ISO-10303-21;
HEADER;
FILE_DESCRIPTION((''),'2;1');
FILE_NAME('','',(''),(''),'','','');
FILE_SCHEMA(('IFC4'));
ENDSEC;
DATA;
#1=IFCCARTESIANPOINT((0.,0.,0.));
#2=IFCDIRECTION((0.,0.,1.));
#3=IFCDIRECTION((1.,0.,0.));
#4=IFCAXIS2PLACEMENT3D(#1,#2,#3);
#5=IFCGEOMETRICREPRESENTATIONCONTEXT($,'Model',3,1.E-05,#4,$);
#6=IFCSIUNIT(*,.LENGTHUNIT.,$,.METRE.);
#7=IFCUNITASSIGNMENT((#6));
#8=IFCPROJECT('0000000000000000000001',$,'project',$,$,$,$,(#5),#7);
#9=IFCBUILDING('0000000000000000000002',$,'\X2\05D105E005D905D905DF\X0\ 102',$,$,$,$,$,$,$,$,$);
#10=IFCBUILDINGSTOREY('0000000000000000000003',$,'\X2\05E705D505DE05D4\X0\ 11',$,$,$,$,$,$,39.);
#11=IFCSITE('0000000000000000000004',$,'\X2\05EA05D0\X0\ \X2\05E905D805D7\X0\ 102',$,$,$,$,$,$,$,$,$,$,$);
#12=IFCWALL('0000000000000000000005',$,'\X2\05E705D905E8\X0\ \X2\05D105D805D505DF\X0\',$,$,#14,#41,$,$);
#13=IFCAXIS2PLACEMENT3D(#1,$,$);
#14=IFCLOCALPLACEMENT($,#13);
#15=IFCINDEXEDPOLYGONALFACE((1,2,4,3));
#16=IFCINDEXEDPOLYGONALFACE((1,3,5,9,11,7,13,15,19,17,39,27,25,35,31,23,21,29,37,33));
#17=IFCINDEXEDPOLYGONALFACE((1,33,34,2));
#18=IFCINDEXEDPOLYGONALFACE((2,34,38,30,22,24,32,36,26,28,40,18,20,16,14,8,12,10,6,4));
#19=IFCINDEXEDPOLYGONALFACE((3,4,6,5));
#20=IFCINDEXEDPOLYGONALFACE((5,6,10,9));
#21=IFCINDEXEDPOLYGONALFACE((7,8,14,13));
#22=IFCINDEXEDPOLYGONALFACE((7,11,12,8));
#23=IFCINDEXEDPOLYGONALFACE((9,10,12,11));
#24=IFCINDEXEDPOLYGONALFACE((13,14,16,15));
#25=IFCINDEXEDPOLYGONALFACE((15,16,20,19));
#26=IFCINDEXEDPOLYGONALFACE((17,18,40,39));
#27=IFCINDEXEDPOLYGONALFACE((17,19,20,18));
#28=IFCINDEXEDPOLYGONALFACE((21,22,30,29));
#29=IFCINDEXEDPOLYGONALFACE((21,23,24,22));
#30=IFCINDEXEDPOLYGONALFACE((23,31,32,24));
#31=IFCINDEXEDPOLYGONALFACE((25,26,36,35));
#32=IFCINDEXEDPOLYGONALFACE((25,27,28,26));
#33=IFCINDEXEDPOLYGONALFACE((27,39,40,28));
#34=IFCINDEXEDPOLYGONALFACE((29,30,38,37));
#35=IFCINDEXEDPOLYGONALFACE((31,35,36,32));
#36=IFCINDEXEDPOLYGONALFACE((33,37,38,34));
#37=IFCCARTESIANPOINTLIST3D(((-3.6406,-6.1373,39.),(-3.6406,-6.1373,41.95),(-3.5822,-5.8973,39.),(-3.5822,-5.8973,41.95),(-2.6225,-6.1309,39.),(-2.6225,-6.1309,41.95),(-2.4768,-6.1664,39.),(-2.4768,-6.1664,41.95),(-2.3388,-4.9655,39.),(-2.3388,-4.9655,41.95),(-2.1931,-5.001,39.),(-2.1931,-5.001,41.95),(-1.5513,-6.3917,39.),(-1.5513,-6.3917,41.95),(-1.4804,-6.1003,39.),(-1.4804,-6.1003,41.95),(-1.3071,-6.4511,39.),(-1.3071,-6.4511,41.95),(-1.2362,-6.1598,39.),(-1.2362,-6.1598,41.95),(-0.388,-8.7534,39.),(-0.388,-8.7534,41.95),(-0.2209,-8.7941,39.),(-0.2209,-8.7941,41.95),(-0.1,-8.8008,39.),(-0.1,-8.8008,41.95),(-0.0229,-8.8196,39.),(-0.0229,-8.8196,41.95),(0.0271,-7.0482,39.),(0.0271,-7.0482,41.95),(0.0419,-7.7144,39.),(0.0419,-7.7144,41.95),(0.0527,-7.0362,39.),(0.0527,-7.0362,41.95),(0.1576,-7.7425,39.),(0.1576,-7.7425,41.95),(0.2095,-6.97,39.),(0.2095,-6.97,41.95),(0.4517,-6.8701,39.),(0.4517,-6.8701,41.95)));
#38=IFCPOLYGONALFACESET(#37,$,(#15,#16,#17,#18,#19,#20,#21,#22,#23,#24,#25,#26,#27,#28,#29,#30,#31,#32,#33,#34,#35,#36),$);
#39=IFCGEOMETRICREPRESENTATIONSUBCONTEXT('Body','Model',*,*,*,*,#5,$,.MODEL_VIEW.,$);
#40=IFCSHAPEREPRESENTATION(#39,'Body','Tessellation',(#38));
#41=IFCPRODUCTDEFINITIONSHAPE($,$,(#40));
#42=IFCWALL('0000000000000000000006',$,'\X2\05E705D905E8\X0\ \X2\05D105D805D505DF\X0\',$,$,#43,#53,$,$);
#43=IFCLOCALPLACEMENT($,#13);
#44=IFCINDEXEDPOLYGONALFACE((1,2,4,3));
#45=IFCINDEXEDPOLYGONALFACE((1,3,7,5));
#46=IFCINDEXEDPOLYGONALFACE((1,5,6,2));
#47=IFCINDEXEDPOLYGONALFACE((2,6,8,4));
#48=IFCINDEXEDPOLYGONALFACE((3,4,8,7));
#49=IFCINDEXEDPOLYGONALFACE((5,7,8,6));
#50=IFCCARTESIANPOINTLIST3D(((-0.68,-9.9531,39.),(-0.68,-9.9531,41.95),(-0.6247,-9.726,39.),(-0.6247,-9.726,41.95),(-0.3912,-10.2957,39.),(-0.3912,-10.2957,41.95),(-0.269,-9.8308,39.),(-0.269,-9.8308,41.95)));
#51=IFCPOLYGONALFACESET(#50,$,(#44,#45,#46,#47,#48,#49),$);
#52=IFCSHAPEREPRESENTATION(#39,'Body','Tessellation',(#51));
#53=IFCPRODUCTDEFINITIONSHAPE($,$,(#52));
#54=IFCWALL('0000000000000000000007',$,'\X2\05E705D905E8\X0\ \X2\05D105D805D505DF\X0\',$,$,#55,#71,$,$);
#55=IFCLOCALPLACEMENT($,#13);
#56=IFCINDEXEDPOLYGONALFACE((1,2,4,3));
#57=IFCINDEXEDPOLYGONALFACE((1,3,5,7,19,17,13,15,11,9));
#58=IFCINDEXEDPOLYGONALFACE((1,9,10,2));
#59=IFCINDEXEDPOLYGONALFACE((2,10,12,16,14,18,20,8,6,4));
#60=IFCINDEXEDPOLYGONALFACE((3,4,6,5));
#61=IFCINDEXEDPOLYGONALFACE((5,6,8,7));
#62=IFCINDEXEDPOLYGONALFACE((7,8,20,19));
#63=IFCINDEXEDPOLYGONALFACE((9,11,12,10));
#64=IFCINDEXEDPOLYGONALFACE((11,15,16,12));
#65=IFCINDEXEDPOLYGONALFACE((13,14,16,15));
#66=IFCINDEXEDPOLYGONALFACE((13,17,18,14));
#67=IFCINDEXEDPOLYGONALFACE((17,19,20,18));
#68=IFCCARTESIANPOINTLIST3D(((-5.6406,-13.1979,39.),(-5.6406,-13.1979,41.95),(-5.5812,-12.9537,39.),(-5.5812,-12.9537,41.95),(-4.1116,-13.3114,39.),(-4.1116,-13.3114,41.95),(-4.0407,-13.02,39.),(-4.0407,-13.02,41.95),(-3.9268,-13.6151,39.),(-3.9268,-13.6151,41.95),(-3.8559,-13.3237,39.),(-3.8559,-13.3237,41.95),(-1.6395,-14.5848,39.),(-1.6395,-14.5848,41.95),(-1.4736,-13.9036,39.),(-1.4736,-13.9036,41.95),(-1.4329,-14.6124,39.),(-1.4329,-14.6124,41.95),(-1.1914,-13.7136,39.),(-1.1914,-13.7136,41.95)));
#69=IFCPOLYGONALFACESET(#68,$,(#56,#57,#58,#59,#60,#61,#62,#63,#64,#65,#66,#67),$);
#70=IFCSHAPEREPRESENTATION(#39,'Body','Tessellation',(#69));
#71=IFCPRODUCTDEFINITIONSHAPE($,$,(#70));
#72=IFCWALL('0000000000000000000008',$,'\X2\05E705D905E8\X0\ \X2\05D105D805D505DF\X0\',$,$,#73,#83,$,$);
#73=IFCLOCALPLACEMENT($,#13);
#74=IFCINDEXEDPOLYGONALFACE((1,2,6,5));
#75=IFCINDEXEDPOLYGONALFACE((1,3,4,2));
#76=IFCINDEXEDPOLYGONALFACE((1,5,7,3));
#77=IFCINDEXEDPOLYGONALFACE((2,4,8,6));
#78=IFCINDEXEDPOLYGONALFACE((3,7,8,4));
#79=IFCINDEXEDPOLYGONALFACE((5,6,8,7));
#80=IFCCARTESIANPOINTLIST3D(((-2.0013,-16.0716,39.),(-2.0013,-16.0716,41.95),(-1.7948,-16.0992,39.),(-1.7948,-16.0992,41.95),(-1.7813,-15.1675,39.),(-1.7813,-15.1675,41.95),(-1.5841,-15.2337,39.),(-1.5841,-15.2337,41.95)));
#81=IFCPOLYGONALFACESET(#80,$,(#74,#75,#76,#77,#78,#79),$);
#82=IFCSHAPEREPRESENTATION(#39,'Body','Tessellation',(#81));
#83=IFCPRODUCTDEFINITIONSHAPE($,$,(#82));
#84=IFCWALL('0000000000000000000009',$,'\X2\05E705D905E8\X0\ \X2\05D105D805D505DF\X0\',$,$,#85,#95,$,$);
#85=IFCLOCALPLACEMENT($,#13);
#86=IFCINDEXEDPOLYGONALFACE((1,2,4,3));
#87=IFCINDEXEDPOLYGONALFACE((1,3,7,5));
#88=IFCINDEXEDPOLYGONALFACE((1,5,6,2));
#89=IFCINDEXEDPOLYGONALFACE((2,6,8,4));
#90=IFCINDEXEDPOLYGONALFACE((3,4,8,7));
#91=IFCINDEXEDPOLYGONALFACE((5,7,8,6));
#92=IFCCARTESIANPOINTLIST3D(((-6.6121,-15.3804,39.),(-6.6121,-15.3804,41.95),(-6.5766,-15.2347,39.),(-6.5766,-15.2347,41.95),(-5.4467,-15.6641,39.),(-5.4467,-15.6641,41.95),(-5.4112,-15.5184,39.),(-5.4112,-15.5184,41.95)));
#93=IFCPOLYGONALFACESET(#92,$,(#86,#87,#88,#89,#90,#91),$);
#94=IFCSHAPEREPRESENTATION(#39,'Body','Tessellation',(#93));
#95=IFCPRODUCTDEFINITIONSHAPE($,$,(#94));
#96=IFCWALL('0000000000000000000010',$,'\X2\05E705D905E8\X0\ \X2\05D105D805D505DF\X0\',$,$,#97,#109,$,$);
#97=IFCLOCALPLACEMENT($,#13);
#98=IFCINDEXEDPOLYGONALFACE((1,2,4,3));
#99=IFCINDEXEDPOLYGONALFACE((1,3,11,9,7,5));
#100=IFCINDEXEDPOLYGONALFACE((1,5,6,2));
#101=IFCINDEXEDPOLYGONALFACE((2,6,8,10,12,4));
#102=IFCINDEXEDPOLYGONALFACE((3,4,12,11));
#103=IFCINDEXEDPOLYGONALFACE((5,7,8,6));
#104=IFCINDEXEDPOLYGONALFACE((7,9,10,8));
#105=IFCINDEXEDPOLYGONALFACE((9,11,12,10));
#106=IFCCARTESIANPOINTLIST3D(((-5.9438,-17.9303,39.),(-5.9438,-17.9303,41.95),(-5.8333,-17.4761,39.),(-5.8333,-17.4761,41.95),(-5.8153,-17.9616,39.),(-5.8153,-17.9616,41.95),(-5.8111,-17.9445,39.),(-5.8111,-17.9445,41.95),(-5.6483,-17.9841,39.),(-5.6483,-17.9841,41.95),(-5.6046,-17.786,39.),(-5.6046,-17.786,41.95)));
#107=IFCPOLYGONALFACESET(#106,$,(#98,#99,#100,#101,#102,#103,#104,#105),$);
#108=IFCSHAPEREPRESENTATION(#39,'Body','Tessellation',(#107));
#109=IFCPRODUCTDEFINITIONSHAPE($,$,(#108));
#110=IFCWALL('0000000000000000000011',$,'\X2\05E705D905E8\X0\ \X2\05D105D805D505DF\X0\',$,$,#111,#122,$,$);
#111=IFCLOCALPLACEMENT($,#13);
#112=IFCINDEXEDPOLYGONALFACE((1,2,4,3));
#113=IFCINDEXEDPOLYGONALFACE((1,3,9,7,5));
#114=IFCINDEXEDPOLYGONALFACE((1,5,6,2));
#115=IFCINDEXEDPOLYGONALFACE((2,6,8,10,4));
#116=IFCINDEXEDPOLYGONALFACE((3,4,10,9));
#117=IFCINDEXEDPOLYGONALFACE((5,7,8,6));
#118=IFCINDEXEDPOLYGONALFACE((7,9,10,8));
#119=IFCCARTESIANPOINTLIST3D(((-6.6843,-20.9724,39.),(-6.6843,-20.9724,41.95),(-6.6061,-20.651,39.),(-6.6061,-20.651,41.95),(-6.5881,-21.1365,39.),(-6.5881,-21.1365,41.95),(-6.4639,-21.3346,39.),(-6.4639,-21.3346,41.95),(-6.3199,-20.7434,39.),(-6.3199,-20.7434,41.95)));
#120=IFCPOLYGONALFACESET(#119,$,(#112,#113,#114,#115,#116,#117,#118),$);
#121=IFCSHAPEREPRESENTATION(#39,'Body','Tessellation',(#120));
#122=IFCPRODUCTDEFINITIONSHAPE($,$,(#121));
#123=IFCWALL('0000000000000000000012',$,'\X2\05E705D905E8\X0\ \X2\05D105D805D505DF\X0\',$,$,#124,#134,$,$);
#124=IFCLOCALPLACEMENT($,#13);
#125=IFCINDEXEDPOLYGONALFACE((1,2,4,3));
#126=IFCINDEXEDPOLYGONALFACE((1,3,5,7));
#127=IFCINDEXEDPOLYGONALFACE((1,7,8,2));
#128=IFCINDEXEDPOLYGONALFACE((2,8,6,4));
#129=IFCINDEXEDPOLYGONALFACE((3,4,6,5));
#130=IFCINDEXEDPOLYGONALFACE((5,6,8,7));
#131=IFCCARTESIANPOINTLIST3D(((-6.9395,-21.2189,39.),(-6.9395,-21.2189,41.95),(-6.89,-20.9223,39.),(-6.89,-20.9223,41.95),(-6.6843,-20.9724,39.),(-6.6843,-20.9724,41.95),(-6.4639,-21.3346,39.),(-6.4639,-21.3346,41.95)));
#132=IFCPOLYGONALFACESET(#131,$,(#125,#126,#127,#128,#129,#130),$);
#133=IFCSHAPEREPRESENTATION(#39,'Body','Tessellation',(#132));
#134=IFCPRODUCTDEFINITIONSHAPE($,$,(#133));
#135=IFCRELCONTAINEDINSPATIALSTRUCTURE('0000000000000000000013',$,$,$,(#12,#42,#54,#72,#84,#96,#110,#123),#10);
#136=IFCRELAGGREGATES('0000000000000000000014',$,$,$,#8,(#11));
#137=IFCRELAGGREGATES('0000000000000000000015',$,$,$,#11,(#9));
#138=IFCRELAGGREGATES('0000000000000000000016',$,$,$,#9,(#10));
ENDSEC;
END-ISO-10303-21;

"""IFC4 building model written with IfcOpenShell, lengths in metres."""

from ifc_helpers import new_model, si_unit, frame, origin_with_axes, context, subcontext, project, spatial, polyline, outline, extrude, element, save


model = new_model("IFC4")

# Units and contexts
model_context = context("Model", 3, precision=1e-05, world=origin_with_axes())
body_context = subcontext(model_context, "Body", "Model", "MODEL_VIEW")
ifc_project = project(units=[si_unit("LENGTHUNIT", "METRE")], contexts=[model_context])

# Site, building, storey
site = spatial("IfcSite", under=ifc_project, Name="תא שטח 102")
building = spatial("IfcBuilding", under=site, Name="בניין 102")
storey = spatial("IfcBuildingStorey", under=building, Name="קומה 11", Elevation=39.0)

# Walls
element("IfcWall", 1, inside=storey, Name="קיר בטון", context=body_context, shape_type="SweptSolid", body=[
    extrude(outline(polyline([(-2.3388, -4.9655), (-2.6225, -6.1309), (-3.5822, -5.8973), (-3.6406, -6.1373), (0.0527, -7.0362), (0.2095, -6.97), (0.0271, -7.0482), (-0.388, -8.7534), (-0.2209, -8.7941), (0.0419, -7.7144), (0.1576, -7.7425), (-0.1, -8.8008), (-0.0229, -8.8196), (0.4517, -6.8701), (-1.3071, -6.4511), (-1.2362, -6.1598), (-1.4804, -6.1003), (-1.5513, -6.3917), (-2.4768, -6.1664), (-2.1931, -5.001), (-2.3388, -4.9655)])), frame((0.0, 0.0, 39.0)), (0.0, 0.0, 1.0), 2.95),
])
element("IfcWall", 2, inside=storey, Name="קיר בטון", context=body_context, shape_type="SweptSolid", body=[
    extrude(outline(polyline([(-0.3912, -10.2957), (-0.269, -9.8308), (-0.6247, -9.726), (-0.68, -9.9531), (-0.3912, -10.2957)])), frame((0.0, 0.0, 39.0)), (0.0, 0.0, 1.0), 2.95),
])
element("IfcWall", 3, inside=storey, Name="קיר בטון", context=body_context, shape_type="SweptSolid", body=[
    extrude(outline(polyline([(-5.6406, -13.1979), (-3.9268, -13.6151), (-3.8559, -13.3237), (-1.4736, -13.9036), (-1.6395, -14.5848), (-1.4329, -14.6124), (-1.1914, -13.7136), (-4.0407, -13.02), (-4.1116, -13.3114), (-5.5812, -12.9537), (-5.6406, -13.1979)])), frame((0.0, 0.0, 39.0)), (0.0, 0.0, 1.0), 2.95),
])
element("IfcWall", 4, inside=storey, Name="קיר בטון", context=body_context, shape_type="SweptSolid", body=[
    extrude(outline(polyline([(-2.0013, -16.0716), (-1.7948, -16.0992), (-1.5841, -15.2337), (-1.7813, -15.1675), (-2.0013, -16.0716)])), frame((0.0, 0.0, 39.0)), (0.0, 0.0, 1.0), 2.95),
])
element("IfcWall", 5, inside=storey, Name="קיר בטון", context=body_context, shape_type="SweptSolid", body=[
    extrude(outline(polyline([(-6.5766, -15.2347), (-6.6121, -15.3804), (-5.4467, -15.6641), (-5.4112, -15.5184), (-6.5766, -15.2347)])), frame((0.0, 0.0, 39.0)), (0.0, 0.0, 1.0), 2.95),
])
element("IfcWall", 6, inside=storey, Name="קיר בטון", context=body_context, shape_type="SweptSolid", body=[
    extrude(outline(polyline([(-5.8153, -17.9616), (-5.8111, -17.9445), (-5.6483, -17.9841), (-5.6046, -17.786), (-5.8333, -17.4761), (-5.9438, -17.9303), (-5.8153, -17.9616)])), frame((0.0, 0.0, 39.0)), (0.0, 0.0, 1.0), 2.95),
])
element("IfcWall", 7, inside=storey, Name="קיר בטון", context=body_context, shape_type="SweptSolid", body=[
    extrude(outline(polyline([(-6.3199, -20.7434), (-6.6061, -20.651), (-6.6843, -20.9724), (-6.5881, -21.1365), (-6.4639, -21.3346), (-6.3199, -20.7434)])), frame((0.0, 0.0, 39.0)), (0.0, 0.0, 1.0), 2.95),
])
element("IfcWall", 8, inside=storey, Name="קיר בטון", context=body_context, shape_type="SweptSolid", body=[
    extrude(outline(polyline([(-6.6843, -20.9724), (-6.89, -20.9223), (-6.9395, -21.2189), (-6.4639, -21.3346), (-6.6843, -20.9724)])), frame((0.0, 0.0, 39.0)), (0.0, 0.0, 1.0), 2.95),
])

save(model, "model.ifc")
